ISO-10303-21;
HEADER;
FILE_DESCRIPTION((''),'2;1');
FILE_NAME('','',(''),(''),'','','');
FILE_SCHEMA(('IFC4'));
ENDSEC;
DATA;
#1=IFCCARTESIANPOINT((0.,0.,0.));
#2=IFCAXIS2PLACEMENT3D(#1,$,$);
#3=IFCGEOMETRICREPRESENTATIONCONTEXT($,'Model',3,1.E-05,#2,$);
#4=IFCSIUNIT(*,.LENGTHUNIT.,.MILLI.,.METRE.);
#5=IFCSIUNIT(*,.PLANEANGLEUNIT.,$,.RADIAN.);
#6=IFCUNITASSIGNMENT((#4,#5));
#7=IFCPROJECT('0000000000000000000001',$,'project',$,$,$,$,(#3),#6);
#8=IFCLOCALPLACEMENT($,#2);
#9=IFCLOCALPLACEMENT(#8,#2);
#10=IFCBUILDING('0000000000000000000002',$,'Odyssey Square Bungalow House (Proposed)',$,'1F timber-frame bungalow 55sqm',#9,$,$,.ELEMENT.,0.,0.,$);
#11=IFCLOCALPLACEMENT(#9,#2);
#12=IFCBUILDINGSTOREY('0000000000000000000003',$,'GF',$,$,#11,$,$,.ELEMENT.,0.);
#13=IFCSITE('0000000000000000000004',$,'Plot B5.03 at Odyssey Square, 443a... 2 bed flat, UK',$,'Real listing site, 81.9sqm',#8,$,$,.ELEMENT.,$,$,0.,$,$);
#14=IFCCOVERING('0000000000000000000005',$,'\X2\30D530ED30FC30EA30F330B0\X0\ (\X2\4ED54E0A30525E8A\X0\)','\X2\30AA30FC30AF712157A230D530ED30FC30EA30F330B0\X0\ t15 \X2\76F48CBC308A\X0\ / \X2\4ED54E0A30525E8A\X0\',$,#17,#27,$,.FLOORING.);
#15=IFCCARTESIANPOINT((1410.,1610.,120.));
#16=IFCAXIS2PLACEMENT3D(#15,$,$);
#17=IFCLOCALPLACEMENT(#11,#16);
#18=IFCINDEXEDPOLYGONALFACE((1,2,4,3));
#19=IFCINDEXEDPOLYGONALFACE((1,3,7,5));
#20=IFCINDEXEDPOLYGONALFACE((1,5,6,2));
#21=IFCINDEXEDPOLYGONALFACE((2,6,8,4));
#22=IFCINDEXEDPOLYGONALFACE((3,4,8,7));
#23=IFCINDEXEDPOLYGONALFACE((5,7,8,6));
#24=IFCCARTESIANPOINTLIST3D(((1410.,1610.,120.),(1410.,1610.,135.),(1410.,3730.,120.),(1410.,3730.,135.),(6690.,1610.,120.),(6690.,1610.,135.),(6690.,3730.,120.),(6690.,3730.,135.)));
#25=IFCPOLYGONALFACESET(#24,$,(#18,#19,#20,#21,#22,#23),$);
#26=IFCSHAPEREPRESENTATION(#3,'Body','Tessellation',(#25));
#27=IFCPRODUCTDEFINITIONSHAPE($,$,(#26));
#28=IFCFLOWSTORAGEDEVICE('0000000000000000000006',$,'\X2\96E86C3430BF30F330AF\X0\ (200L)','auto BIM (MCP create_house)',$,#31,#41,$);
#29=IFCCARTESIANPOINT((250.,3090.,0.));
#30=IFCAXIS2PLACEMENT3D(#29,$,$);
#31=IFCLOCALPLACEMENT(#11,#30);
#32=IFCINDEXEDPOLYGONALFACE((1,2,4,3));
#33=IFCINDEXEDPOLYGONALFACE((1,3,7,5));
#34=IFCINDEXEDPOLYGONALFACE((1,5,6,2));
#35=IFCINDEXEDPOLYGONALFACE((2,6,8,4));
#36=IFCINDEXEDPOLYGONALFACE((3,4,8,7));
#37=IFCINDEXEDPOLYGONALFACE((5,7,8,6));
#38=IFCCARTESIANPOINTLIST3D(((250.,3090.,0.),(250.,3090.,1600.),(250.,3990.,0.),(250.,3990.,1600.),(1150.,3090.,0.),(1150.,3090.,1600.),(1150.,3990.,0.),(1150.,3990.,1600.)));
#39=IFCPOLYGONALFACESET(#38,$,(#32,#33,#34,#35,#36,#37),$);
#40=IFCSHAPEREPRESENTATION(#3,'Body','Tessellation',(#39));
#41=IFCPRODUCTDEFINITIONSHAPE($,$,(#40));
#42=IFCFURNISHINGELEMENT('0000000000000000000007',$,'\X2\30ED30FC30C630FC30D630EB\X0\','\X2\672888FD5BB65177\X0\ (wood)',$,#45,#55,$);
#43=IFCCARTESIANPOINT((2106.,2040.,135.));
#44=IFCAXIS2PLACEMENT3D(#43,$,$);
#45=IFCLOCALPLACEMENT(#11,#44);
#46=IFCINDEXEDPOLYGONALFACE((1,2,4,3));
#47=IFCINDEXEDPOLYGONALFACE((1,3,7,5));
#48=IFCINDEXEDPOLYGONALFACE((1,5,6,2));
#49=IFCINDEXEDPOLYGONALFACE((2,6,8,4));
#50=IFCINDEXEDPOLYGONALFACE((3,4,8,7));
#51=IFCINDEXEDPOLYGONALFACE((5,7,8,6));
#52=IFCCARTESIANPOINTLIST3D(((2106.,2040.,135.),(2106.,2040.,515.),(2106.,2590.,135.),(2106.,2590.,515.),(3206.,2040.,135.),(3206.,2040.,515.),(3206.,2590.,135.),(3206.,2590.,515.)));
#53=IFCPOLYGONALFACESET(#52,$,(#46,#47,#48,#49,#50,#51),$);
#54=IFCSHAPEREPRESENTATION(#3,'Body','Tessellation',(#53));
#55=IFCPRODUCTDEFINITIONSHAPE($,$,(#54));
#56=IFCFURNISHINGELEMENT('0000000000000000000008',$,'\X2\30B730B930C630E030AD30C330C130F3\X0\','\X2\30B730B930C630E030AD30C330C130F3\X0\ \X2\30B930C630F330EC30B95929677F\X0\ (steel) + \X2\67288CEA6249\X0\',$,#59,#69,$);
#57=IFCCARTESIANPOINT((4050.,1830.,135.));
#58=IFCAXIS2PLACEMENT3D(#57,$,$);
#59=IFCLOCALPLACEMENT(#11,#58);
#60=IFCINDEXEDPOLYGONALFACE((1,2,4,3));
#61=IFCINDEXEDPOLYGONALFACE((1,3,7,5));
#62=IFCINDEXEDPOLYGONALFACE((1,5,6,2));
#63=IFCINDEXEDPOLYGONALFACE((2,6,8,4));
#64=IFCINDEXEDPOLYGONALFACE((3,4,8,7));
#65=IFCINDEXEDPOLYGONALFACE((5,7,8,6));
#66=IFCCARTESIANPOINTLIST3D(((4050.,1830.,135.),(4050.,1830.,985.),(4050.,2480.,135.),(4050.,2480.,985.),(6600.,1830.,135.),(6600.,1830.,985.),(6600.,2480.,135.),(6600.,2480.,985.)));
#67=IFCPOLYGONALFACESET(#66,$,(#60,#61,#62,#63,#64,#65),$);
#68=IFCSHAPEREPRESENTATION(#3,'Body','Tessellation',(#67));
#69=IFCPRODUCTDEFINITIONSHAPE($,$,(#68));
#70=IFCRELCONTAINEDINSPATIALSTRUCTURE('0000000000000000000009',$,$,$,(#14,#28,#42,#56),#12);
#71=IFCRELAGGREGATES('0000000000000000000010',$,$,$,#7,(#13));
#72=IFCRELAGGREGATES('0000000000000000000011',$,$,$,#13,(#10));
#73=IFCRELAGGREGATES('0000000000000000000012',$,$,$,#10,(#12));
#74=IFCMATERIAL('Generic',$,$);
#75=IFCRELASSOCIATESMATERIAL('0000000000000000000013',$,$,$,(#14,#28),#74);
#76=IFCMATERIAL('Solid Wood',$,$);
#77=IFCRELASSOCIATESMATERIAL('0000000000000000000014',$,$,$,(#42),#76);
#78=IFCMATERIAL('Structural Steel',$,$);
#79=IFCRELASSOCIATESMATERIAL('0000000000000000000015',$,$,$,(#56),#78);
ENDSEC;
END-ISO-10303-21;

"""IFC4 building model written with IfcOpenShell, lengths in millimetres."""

from ifc_helpers import new_model, si_unit, frame, frame_2d, origin, place, context, project, spatial, rectangle, extrude, material, element, save


model = new_model("IFC4")

# Units and contexts
model_context = context("Model", 3, precision=1e-05, world=origin())
ifc_project = project(units=[si_unit("LENGTHUNIT", "METRE", prefix="MILLI"), si_unit("PLANEANGLEUNIT", "RADIAN")], contexts=[model_context])

# Site, building, storey
site_placement = place(None, origin())
site = spatial("IfcSite", under=ifc_project, at=site_placement, Name="Plot B5.03 at Odyssey Square, 443a... 2 bed flat, UK", ObjectType="Real listing site, 81.9sqm", CompositionType="ELEMENT", RefElevation=0.0)
building_placement = place(site_placement, origin())
building = spatial("IfcBuilding", under=site, at=building_placement, Name="Odyssey Square Bungalow House (Proposed)", ObjectType="1F timber-frame bungalow 55sqm", CompositionType="ELEMENT", ElevationOfRefHeight=0.0, ElevationOfTerrain=0.0)
storey_placement = place(building_placement, origin())
storey = spatial("IfcBuildingStorey", under=building, at=storey_placement, Name="GF", CompositionType="ELEMENT", Elevation=0.0)

# Shared definitions
ifc_material_1 = material(Name="Solid Wood")

# Covering
ifc_material_2 = material(Name="Generic")
covering_placement = place(storey_placement, frame((1410.0, 1610.0, 120.0)))
element("IfcCovering", 1, at=covering_placement, inside=storey, material=ifc_material_2, Name="フローリング (仕上げ床)", Description="オーク無垢フローリング t15 直貼り / 仕上げ床", PredefinedType="FLOORING", context=model_context, shape_type="SweptSolid", body=[
    extrude(rectangle(XDim=5280.0, YDim=2120.0, at=frame_2d((2640.0, 1060.0))), frame((1410.0, 1610.0, 120.0)), (0.0, 0.0, 1.0), 15.0),
])

# Flow storage device
flow_storage_device_placement = place(storey_placement, frame((250.0, 3090.0, 0.0)))
element("IfcFlowStorageDevice", 2, at=flow_storage_device_placement, inside=storey, material=ifc_material_2, Name="雨水タンク (200L)", Description="auto BIM (MCP create_house)", context=model_context, shape_type="SweptSolid", body=[
    extrude(rectangle(XDim=900.0, YDim=900.0, at=frame_2d((450.0, 450.0))), frame((250.0, 3090.0, 0.0)), (0.0, 0.0, 1.0), 1600.0),
])

# Furnishing elements
furnishing_1_placement = place(storey_placement, frame((2106.0, 2040.0, 135.0)))
element("IfcFurnishingElement", 3, at=furnishing_1_placement, inside=storey, material=ifc_material_1, Name="ローテーブル", Description="木製家具 (wood)", context=model_context, shape_type="SweptSolid", body=[
    extrude(rectangle(XDim=1100.0, YDim=550.0, at=frame_2d((550.0, 275.0))), frame((2106.0, 2040.0, 135.0)), (0.0, 0.0, 1.0), 380.0),
])
ifc_material_3 = material(Name="Structural Steel")
furnishing_2_placement = place(storey_placement, frame((4050.0, 1830.0, 135.0)))
element("IfcFurnishingElement", 4, at=furnishing_2_placement, inside=storey, material=ifc_material_3, Name="システムキッチン", Description="システムキッチン ステンレス天板 (steel) + 木質扉", context=model_context, shape_type="SweptSolid", body=[
    extrude(rectangle(XDim=2550.0, YDim=650.0, at=frame_2d((1275.0, 325.0))), frame((4050.0, 1830.0, 135.0)), (0.0, 0.0, 1.0), 850.0),
])

save(model, "model.ifc")
